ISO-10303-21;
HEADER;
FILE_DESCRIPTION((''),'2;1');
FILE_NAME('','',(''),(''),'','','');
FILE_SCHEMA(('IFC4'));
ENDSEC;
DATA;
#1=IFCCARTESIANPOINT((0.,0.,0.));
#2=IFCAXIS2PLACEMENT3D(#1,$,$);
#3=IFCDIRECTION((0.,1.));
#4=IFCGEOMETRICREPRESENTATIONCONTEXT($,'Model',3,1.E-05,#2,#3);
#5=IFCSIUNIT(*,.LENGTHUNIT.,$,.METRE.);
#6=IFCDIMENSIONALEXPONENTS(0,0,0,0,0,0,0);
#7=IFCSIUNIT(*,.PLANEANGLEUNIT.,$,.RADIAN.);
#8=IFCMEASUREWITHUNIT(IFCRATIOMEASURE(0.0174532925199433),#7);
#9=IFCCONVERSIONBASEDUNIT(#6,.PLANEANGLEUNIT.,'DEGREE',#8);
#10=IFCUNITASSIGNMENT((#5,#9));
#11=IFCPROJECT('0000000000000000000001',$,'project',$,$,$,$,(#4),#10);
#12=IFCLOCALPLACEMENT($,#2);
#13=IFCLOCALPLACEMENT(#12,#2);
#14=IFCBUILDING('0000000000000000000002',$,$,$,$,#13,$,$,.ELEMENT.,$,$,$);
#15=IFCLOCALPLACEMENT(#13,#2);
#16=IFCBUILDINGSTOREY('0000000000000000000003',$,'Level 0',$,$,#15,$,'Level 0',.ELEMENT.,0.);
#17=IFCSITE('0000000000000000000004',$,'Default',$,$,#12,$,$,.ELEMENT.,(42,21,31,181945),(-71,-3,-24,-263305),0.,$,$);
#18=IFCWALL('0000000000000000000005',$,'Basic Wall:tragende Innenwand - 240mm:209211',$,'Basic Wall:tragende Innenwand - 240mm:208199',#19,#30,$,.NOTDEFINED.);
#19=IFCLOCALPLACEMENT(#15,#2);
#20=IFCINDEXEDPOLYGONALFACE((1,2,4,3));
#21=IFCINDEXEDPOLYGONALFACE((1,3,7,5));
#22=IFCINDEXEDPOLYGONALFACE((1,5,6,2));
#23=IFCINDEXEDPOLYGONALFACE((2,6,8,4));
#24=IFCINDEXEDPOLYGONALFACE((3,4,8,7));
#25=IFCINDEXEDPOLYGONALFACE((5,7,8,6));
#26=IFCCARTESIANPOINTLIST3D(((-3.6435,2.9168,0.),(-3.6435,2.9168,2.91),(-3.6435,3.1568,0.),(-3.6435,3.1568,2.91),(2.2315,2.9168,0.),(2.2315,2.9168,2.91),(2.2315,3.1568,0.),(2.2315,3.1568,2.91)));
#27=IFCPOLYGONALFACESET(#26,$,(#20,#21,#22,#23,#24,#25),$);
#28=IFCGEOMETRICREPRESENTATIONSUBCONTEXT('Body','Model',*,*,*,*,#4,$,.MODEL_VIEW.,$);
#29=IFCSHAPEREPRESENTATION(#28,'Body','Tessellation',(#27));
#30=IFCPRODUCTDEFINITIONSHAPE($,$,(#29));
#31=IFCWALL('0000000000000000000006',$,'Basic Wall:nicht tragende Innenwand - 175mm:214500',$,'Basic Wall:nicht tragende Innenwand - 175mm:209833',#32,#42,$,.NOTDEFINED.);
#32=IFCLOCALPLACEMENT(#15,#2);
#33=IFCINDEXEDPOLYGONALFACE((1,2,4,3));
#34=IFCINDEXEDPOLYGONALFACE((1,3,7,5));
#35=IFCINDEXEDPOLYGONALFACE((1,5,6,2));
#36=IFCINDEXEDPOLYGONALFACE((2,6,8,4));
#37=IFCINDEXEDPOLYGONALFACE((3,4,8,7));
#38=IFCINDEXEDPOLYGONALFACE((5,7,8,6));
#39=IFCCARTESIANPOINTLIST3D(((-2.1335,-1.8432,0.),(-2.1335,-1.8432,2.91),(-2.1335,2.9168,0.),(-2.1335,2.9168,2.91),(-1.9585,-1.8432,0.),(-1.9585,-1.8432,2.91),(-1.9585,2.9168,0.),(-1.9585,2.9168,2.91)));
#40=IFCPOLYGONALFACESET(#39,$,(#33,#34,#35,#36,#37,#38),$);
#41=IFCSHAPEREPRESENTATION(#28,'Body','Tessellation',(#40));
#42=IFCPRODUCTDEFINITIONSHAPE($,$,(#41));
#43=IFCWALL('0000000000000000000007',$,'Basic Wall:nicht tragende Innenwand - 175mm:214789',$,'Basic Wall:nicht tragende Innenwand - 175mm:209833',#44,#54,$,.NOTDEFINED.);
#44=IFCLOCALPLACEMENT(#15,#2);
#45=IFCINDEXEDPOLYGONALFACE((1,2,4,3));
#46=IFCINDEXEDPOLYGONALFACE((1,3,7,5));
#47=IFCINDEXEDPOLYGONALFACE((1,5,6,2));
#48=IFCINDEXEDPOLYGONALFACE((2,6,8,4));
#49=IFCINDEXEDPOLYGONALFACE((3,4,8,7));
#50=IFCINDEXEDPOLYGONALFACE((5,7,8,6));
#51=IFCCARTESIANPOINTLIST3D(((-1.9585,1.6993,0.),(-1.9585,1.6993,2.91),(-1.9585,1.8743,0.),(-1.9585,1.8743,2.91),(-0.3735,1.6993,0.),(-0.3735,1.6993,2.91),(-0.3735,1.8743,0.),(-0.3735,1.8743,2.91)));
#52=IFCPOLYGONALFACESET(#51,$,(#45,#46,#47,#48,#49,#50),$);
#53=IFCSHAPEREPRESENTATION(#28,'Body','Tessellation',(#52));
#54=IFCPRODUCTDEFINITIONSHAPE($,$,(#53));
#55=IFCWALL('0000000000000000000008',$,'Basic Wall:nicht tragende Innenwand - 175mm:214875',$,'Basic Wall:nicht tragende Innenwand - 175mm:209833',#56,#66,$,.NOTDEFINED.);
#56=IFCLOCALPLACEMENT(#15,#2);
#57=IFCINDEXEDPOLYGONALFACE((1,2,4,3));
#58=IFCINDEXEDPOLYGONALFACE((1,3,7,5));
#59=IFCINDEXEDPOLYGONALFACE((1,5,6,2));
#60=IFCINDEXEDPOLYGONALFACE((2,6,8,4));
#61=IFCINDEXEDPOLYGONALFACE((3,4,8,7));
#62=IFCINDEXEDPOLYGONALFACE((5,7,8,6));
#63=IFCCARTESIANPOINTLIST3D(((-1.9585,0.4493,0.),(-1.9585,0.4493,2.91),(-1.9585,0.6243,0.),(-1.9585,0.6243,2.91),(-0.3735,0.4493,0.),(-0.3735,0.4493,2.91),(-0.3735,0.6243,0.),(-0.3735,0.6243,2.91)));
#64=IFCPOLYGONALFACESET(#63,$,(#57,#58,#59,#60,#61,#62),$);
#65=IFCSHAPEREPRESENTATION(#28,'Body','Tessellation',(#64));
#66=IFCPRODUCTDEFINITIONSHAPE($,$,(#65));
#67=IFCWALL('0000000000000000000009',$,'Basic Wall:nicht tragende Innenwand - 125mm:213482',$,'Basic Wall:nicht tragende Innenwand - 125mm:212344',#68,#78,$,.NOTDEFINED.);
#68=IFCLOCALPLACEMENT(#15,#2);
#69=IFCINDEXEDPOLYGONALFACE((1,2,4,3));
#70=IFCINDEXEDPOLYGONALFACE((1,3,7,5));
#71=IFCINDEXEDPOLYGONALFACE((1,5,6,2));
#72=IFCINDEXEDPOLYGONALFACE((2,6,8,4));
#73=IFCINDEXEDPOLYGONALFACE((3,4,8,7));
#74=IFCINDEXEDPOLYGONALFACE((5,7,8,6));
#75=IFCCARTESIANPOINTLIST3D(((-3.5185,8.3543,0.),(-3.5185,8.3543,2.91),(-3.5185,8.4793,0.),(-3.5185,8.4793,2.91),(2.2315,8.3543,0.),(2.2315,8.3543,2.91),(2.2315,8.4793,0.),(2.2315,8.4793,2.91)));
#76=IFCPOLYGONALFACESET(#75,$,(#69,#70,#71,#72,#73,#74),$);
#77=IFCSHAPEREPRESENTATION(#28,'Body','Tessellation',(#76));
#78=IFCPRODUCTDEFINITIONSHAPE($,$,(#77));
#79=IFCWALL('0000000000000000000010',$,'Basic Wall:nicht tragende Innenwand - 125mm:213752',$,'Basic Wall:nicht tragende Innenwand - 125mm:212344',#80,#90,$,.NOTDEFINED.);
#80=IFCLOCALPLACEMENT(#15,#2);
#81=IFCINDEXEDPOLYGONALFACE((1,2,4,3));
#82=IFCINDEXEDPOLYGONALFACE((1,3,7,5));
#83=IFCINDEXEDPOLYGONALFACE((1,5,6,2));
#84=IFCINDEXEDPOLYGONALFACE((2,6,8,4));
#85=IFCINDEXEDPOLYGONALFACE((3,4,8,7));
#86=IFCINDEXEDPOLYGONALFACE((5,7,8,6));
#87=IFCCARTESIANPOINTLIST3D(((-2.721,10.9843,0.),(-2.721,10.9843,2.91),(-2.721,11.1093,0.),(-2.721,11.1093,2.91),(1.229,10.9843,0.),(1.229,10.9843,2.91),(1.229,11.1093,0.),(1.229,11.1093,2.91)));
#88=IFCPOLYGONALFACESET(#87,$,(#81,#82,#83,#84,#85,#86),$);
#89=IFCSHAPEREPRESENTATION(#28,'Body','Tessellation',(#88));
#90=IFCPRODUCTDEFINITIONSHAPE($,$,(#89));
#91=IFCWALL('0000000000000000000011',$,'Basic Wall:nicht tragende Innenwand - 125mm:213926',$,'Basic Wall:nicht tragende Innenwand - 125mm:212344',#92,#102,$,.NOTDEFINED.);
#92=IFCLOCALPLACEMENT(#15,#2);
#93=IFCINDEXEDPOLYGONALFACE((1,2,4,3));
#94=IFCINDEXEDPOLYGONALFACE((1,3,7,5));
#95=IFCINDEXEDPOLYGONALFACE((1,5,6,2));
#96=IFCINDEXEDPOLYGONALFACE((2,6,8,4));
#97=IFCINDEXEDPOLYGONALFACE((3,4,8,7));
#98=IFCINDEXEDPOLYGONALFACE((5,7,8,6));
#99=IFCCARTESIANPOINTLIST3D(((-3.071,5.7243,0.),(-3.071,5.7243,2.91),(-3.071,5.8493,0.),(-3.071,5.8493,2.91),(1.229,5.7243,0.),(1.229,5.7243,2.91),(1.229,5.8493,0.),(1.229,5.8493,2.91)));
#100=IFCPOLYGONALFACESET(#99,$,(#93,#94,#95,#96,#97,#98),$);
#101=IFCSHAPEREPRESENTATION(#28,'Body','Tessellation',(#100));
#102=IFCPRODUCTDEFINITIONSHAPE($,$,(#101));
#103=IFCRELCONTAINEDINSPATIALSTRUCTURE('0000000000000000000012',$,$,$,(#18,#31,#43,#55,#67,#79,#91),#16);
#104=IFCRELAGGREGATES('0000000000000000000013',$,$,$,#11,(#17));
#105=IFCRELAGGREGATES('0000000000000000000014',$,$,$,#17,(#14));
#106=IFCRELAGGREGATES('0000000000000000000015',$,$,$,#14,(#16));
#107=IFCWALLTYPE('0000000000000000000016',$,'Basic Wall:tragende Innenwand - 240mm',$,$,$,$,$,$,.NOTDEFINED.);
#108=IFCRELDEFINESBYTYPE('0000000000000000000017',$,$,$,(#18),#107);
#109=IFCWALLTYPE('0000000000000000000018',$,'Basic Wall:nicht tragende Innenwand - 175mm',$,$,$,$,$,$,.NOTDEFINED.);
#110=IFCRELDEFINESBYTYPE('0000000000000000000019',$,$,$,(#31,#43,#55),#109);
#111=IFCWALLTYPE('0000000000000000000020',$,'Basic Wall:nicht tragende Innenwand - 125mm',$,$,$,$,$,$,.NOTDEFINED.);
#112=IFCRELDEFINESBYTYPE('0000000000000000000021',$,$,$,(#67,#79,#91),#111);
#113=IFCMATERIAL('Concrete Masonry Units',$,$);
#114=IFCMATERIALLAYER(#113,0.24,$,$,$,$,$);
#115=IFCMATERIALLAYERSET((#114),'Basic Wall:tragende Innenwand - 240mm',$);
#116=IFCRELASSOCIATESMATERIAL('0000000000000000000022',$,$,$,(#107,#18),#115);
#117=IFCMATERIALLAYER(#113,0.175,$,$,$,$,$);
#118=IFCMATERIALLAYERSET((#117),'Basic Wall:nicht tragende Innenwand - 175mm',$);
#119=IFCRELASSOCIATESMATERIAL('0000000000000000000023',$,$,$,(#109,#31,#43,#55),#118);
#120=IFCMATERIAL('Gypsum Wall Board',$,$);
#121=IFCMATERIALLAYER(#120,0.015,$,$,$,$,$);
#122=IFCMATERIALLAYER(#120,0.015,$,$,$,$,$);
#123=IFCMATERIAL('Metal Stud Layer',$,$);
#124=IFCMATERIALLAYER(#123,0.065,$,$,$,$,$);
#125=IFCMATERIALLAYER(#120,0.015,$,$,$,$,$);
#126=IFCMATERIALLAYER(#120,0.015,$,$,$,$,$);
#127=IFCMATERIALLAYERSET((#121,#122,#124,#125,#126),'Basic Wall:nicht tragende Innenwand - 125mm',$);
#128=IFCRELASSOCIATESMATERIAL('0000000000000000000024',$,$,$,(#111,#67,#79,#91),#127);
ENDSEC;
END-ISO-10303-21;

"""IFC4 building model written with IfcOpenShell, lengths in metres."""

from ifc_helpers import new_model, entity, si_unit, converted_unit, direction, frame, frame_2d, origin, place, context, subcontext, project, spatial, polyline, rectangle, extrude, clip, bounded_halfspace, material, layer, layer_set, layer_usage, type_object, element, save


model = new_model("IFC4")

# Units and contexts
model_context = context("Model", 3, precision=1e-05, world=origin(), true_north=direction((0.0, 1.0)))
body_context = subcontext(model_context, "Body", "Model", "MODEL_VIEW")
ifc_project = project(units=[si_unit("LENGTHUNIT", "METRE"), converted_unit("PLANEANGLEUNIT", "DEGREE", entity("IfcRatioMeasure", 0.0174532925199433), si_unit("PLANEANGLEUNIT", "RADIAN"), dimensions=[0, 0, 0, 0, 0, 0, 0])], contexts=[model_context])

# Site, building, storey
site_placement = place(None, origin())
site = spatial("IfcSite", under=ifc_project, at=site_placement, Name="Default", CompositionType="ELEMENT", RefLatitude=(42, 21, 31, 181945), RefLongitude=(-71, -3, -24, -263305), RefElevation=0.0)
building_placement = place(site_placement, origin())
building = spatial("IfcBuilding", under=site, at=building_placement, CompositionType="ELEMENT")
storey_placement = place(building_placement, origin())
storey = spatial("IfcBuildingStorey", under=building, at=storey_placement, Name="Level 0", LongName="Level 0", CompositionType="ELEMENT", Elevation=0.0)

# Walls
ifc_material_1 = material(Name="Concrete Masonry Units")
ifc_layer_1 = layer(ifc_material_1, 0.24)
ifc_layer_set_1 = layer_set([ifc_layer_1], Name="Basic Wall:tragende Innenwand - 240mm")
ifc_layer_usage_1 = layer_usage(ifc_layer_set_1, "AXIS2", "NEGATIVE", 0.12)
wall_type_1 = type_object("IfcWallType", Name="Basic Wall:tragende Innenwand - 240mm", PredefinedType="NOTDEFINED", material=ifc_layer_set_1)
wall_1_placement = place(storey_placement, frame((2.2315, 3.0368, 0.0), z_axis=(0.0, 0.0, 1.0), x_axis=(-1.0, 0.0, 0.0)))
element("IfcWall", 1, at=wall_1_placement, inside=storey, type_object=wall_type_1, material=ifc_layer_usage_1, Name="Basic Wall:tragende Innenwand - 240mm:209211", ObjectType="Basic Wall:tragende Innenwand - 240mm:208199", PredefinedType="NOTDEFINED", context=body_context, shape_type="Clipping", body=[
    clip(extrude(rectangle(XDim=5.875, YDim=0.24, at=frame_2d((2.9375, 0.0), x_axis=(-1.0, 0.0))), origin(), (0.0, 0.0, 1.0), 2.91), bounded_halfspace(frame((0.0, -0.12, 2.91), z_axis=(0.0, 0.0, -1.0), x_axis=(0.0, 1.0, 0.0)), True, frame((0.0, -0.12, 2.91)), polyline([(0.0, 0.0), (5.875, 0.0), (5.875, 0.24), (5.7, 0.24), (4.365, 0.24), (4.19, 0.24), (2.605, 0.24), (2.43, 0.24), (0.0, 0.24), (0.0, 0.0)]))),
])
ifc_layer_2 = layer(ifc_material_1, 0.175)
ifc_layer_set_2 = layer_set([ifc_layer_2], Name="Basic Wall:nicht tragende Innenwand - 175mm")
ifc_layer_usage_2 = layer_usage(ifc_layer_set_2, "AXIS2", "NEGATIVE", 0.0875)
wall_type_2 = type_object("IfcWallType", Name="Basic Wall:nicht tragende Innenwand - 175mm", PredefinedType="NOTDEFINED", material=ifc_layer_set_2)
wall_2_placement = place(storey_placement, frame((-2.046, 2.9168, 0.0), z_axis=(0.0, 0.0, 1.0), x_axis=(0.0, -1.0, 0.0)))
element("IfcWall", 2, at=wall_2_placement, inside=storey, type_object=wall_type_2, material=ifc_layer_usage_2, Name="Basic Wall:nicht tragende Innenwand - 175mm:214500", ObjectType="Basic Wall:nicht tragende Innenwand - 175mm:209833", PredefinedType="NOTDEFINED", context=body_context, shape_type="Clipping", body=[
    clip(extrude(rectangle(XDim=4.76, YDim=0.175, at=frame_2d((2.38, 0.0), x_axis=(-1.0, 0.0))), origin(), (0.0, 0.0, 1.0), 2.91), bounded_halfspace(frame((0.0, -0.0875, 2.91), z_axis=(0.0, 0.0, -1.0), x_axis=(1.0, 0.0, 0.0)), True, frame((0.0, -0.0875, 2.91)), polyline([(0.0, 0.0), (4.76, 0.0), (4.76, 0.175), (3.7175, 0.175), (3.5425, 0.175), (2.4675, 0.175), (2.2925, 0.175), (1.2175, 0.175), (1.0425, 0.175), (0.0, 0.175), (0.0, 0.0)]))),
])
ifc_layer_usage_3 = layer_usage(ifc_layer_set_2, "AXIS2", "POSITIVE", -0.0875)
wall_3_placement = place(storey_placement, frame((-1.9585, 1.7868, 0.0)))
element("IfcWall", 3, at=wall_3_placement, inside=storey, type_object=wall_type_2, material=ifc_layer_usage_3, Name="Basic Wall:nicht tragende Innenwand - 175mm:214789", ObjectType="Basic Wall:nicht tragende Innenwand - 175mm:209833", PredefinedType="NOTDEFINED", context=body_context, shape_type="Clipping", body=[
    clip(extrude(rectangle(XDim=1.585, YDim=0.175, at=frame_2d((0.7925, 0.0), x_axis=(-1.0, 0.0))), origin(), (0.0, 0.0, 1.0), 2.91), bounded_halfspace(frame((0.0, -0.0875, 2.91), z_axis=(0.0, 0.0, -1.0), x_axis=(0.0, -1.0, 0.0)), True, frame((0.0, -0.0875, 2.91)), polyline([(0.0, 0.0), (1.585, 0.0), (1.585, 0.175), (0.0, 0.175), (0.0, 0.0)]))),
])
ifc_layer_usage_4 = layer_usage(ifc_layer_set_2, "AXIS2", "POSITIVE", -0.0875)
wall_4_placement = place(storey_placement, frame((-1.9585, 0.5368, 0.0)))
element("IfcWall", 4, at=wall_4_placement, inside=storey, type_object=wall_type_2, material=ifc_layer_usage_4, Name="Basic Wall:nicht tragende Innenwand - 175mm:214875", ObjectType="Basic Wall:nicht tragende Innenwand - 175mm:209833", PredefinedType="NOTDEFINED", context=body_context, shape_type="Clipping", body=[
    clip(extrude(rectangle(XDim=1.585, YDim=0.175, at=frame_2d((0.7925, 0.0), x_axis=(-1.0, 0.0))), origin(), (0.0, 0.0, 1.0), 2.91), bounded_halfspace(frame((0.0, -0.0875, 2.91), z_axis=(0.0, 0.0, -1.0), x_axis=(0.0, -1.0, 0.0)), True, frame((0.0, -0.0875, 2.91)), polyline([(0.0, 0.0), (1.585, 0.0), (1.585, 0.175), (0.0, 0.175), (0.0, 0.0)]))),
])
ifc_material_2 = material(Name="Gypsum Wall Board")
ifc_layer_3 = layer(ifc_material_2, 0.015)
ifc_layer_4 = layer(ifc_material_2, 0.015)
ifc_material_3 = material(Name="Metal Stud Layer")
ifc_layer_5 = layer(ifc_material_3, 0.065)
ifc_layer_6 = layer(ifc_material_2, 0.015)
ifc_layer_7 = layer(ifc_material_2, 0.015)
ifc_layer_set_3 = layer_set([ifc_layer_3, ifc_layer_4, ifc_layer_5, ifc_layer_6, ifc_layer_7], Name="Basic Wall:nicht tragende Innenwand - 125mm")
ifc_layer_usage_5 = layer_usage(ifc_layer_set_3, "AXIS2", "NEGATIVE", 0.0625)
wall_type_3 = type_object("IfcWallType", Name="Basic Wall:nicht tragende Innenwand - 125mm", PredefinedType="NOTDEFINED", material=ifc_layer_set_3)
wall_5_placement = place(storey_placement, frame((-3.5185, 8.4168, 0.0)))
element("IfcWall", 5, at=wall_5_placement, inside=storey, type_object=wall_type_3, material=ifc_layer_usage_5, Name="Basic Wall:nicht tragende Innenwand - 125mm:213482", ObjectType="Basic Wall:nicht tragende Innenwand - 125mm:212344", PredefinedType="NOTDEFINED", context=body_context, shape_type="Clipping", body=[
    clip(extrude(rectangle(XDim=5.75, YDim=0.125, at=frame_2d((2.875, 0.0), x_axis=(-1.0, 0.0))), origin(), (0.0, 0.0, 1.0), 2.91), bounded_halfspace(frame((0.0, -0.0625, 2.91), z_axis=(0.0, 0.0, -1.0), x_axis=(0.0, -1.0, 0.0)), True, frame((0.0, -0.0625, 2.91)), polyline([(0.0, 0.0), (5.75, 0.0), (5.75, 0.125), (0.0, 0.125), (0.0, 0.0)]))),
])
ifc_layer_usage_6 = layer_usage(ifc_layer_set_3, "AXIS2", "NEGATIVE", 0.0625)
wall_6_placement = place(storey_placement, frame((1.229, 11.0468, 0.0), z_axis=(0.0, 0.0, 1.0), x_axis=(-1.0, 0.0, 0.0)))
element("IfcWall", 6, at=wall_6_placement, inside=storey, type_object=wall_type_3, material=ifc_layer_usage_6, Name="Basic Wall:nicht tragende Innenwand - 125mm:213752", ObjectType="Basic Wall:nicht tragende Innenwand - 125mm:212344", PredefinedType="NOTDEFINED", context=body_context, shape_type="Clipping", body=[
    clip(extrude(rectangle(XDim=3.95, YDim=0.125, at=frame_2d((1.975, 0.0), x_axis=(-1.0, 0.0))), origin(), (0.0, 0.0, 1.0), 2.91), bounded_halfspace(frame((0.0, -0.0625, 2.91), z_axis=(0.0, 0.0, -1.0), x_axis=(0.0, 1.0, 0.0)), True, frame((0.0, -0.0625, 2.91)), polyline([(0.0, 0.0), (3.95, 0.0), (3.95, 0.125), (0.0, 0.125), (0.0, 0.0)]))),
])
ifc_layer_usage_7 = layer_usage(ifc_layer_set_3, "AXIS2", "NEGATIVE", 0.0625)
wall_7_placement = place(storey_placement, frame((1.229, 5.7868, 0.0), z_axis=(0.0, 0.0, 1.0), x_axis=(-1.0, 0.0, 0.0)))
element("IfcWall", 7, at=wall_7_placement, inside=storey, type_object=wall_type_3, material=ifc_layer_usage_7, Name="Basic Wall:nicht tragende Innenwand - 125mm:213926", ObjectType="Basic Wall:nicht tragende Innenwand - 125mm:212344", PredefinedType="NOTDEFINED", context=body_context, shape_type="Clipping", body=[
    clip(extrude(rectangle(XDim=4.3, YDim=0.125, at=frame_2d((2.15, 0.0), x_axis=(-1.0, 0.0))), origin(), (0.0, 0.0, 1.0), 2.91), bounded_halfspace(frame((0.0, -0.0625, 2.91), z_axis=(0.0, 0.0, -1.0), x_axis=(0.0, 1.0, 0.0)), True, frame((0.0, -0.0625, 2.91)), polyline([(0.0, 0.0), (4.3, 0.0), (4.3, 0.125), (0.0, 0.125), (0.0, 0.0)]))),
])

save(model, "model.ifc")
